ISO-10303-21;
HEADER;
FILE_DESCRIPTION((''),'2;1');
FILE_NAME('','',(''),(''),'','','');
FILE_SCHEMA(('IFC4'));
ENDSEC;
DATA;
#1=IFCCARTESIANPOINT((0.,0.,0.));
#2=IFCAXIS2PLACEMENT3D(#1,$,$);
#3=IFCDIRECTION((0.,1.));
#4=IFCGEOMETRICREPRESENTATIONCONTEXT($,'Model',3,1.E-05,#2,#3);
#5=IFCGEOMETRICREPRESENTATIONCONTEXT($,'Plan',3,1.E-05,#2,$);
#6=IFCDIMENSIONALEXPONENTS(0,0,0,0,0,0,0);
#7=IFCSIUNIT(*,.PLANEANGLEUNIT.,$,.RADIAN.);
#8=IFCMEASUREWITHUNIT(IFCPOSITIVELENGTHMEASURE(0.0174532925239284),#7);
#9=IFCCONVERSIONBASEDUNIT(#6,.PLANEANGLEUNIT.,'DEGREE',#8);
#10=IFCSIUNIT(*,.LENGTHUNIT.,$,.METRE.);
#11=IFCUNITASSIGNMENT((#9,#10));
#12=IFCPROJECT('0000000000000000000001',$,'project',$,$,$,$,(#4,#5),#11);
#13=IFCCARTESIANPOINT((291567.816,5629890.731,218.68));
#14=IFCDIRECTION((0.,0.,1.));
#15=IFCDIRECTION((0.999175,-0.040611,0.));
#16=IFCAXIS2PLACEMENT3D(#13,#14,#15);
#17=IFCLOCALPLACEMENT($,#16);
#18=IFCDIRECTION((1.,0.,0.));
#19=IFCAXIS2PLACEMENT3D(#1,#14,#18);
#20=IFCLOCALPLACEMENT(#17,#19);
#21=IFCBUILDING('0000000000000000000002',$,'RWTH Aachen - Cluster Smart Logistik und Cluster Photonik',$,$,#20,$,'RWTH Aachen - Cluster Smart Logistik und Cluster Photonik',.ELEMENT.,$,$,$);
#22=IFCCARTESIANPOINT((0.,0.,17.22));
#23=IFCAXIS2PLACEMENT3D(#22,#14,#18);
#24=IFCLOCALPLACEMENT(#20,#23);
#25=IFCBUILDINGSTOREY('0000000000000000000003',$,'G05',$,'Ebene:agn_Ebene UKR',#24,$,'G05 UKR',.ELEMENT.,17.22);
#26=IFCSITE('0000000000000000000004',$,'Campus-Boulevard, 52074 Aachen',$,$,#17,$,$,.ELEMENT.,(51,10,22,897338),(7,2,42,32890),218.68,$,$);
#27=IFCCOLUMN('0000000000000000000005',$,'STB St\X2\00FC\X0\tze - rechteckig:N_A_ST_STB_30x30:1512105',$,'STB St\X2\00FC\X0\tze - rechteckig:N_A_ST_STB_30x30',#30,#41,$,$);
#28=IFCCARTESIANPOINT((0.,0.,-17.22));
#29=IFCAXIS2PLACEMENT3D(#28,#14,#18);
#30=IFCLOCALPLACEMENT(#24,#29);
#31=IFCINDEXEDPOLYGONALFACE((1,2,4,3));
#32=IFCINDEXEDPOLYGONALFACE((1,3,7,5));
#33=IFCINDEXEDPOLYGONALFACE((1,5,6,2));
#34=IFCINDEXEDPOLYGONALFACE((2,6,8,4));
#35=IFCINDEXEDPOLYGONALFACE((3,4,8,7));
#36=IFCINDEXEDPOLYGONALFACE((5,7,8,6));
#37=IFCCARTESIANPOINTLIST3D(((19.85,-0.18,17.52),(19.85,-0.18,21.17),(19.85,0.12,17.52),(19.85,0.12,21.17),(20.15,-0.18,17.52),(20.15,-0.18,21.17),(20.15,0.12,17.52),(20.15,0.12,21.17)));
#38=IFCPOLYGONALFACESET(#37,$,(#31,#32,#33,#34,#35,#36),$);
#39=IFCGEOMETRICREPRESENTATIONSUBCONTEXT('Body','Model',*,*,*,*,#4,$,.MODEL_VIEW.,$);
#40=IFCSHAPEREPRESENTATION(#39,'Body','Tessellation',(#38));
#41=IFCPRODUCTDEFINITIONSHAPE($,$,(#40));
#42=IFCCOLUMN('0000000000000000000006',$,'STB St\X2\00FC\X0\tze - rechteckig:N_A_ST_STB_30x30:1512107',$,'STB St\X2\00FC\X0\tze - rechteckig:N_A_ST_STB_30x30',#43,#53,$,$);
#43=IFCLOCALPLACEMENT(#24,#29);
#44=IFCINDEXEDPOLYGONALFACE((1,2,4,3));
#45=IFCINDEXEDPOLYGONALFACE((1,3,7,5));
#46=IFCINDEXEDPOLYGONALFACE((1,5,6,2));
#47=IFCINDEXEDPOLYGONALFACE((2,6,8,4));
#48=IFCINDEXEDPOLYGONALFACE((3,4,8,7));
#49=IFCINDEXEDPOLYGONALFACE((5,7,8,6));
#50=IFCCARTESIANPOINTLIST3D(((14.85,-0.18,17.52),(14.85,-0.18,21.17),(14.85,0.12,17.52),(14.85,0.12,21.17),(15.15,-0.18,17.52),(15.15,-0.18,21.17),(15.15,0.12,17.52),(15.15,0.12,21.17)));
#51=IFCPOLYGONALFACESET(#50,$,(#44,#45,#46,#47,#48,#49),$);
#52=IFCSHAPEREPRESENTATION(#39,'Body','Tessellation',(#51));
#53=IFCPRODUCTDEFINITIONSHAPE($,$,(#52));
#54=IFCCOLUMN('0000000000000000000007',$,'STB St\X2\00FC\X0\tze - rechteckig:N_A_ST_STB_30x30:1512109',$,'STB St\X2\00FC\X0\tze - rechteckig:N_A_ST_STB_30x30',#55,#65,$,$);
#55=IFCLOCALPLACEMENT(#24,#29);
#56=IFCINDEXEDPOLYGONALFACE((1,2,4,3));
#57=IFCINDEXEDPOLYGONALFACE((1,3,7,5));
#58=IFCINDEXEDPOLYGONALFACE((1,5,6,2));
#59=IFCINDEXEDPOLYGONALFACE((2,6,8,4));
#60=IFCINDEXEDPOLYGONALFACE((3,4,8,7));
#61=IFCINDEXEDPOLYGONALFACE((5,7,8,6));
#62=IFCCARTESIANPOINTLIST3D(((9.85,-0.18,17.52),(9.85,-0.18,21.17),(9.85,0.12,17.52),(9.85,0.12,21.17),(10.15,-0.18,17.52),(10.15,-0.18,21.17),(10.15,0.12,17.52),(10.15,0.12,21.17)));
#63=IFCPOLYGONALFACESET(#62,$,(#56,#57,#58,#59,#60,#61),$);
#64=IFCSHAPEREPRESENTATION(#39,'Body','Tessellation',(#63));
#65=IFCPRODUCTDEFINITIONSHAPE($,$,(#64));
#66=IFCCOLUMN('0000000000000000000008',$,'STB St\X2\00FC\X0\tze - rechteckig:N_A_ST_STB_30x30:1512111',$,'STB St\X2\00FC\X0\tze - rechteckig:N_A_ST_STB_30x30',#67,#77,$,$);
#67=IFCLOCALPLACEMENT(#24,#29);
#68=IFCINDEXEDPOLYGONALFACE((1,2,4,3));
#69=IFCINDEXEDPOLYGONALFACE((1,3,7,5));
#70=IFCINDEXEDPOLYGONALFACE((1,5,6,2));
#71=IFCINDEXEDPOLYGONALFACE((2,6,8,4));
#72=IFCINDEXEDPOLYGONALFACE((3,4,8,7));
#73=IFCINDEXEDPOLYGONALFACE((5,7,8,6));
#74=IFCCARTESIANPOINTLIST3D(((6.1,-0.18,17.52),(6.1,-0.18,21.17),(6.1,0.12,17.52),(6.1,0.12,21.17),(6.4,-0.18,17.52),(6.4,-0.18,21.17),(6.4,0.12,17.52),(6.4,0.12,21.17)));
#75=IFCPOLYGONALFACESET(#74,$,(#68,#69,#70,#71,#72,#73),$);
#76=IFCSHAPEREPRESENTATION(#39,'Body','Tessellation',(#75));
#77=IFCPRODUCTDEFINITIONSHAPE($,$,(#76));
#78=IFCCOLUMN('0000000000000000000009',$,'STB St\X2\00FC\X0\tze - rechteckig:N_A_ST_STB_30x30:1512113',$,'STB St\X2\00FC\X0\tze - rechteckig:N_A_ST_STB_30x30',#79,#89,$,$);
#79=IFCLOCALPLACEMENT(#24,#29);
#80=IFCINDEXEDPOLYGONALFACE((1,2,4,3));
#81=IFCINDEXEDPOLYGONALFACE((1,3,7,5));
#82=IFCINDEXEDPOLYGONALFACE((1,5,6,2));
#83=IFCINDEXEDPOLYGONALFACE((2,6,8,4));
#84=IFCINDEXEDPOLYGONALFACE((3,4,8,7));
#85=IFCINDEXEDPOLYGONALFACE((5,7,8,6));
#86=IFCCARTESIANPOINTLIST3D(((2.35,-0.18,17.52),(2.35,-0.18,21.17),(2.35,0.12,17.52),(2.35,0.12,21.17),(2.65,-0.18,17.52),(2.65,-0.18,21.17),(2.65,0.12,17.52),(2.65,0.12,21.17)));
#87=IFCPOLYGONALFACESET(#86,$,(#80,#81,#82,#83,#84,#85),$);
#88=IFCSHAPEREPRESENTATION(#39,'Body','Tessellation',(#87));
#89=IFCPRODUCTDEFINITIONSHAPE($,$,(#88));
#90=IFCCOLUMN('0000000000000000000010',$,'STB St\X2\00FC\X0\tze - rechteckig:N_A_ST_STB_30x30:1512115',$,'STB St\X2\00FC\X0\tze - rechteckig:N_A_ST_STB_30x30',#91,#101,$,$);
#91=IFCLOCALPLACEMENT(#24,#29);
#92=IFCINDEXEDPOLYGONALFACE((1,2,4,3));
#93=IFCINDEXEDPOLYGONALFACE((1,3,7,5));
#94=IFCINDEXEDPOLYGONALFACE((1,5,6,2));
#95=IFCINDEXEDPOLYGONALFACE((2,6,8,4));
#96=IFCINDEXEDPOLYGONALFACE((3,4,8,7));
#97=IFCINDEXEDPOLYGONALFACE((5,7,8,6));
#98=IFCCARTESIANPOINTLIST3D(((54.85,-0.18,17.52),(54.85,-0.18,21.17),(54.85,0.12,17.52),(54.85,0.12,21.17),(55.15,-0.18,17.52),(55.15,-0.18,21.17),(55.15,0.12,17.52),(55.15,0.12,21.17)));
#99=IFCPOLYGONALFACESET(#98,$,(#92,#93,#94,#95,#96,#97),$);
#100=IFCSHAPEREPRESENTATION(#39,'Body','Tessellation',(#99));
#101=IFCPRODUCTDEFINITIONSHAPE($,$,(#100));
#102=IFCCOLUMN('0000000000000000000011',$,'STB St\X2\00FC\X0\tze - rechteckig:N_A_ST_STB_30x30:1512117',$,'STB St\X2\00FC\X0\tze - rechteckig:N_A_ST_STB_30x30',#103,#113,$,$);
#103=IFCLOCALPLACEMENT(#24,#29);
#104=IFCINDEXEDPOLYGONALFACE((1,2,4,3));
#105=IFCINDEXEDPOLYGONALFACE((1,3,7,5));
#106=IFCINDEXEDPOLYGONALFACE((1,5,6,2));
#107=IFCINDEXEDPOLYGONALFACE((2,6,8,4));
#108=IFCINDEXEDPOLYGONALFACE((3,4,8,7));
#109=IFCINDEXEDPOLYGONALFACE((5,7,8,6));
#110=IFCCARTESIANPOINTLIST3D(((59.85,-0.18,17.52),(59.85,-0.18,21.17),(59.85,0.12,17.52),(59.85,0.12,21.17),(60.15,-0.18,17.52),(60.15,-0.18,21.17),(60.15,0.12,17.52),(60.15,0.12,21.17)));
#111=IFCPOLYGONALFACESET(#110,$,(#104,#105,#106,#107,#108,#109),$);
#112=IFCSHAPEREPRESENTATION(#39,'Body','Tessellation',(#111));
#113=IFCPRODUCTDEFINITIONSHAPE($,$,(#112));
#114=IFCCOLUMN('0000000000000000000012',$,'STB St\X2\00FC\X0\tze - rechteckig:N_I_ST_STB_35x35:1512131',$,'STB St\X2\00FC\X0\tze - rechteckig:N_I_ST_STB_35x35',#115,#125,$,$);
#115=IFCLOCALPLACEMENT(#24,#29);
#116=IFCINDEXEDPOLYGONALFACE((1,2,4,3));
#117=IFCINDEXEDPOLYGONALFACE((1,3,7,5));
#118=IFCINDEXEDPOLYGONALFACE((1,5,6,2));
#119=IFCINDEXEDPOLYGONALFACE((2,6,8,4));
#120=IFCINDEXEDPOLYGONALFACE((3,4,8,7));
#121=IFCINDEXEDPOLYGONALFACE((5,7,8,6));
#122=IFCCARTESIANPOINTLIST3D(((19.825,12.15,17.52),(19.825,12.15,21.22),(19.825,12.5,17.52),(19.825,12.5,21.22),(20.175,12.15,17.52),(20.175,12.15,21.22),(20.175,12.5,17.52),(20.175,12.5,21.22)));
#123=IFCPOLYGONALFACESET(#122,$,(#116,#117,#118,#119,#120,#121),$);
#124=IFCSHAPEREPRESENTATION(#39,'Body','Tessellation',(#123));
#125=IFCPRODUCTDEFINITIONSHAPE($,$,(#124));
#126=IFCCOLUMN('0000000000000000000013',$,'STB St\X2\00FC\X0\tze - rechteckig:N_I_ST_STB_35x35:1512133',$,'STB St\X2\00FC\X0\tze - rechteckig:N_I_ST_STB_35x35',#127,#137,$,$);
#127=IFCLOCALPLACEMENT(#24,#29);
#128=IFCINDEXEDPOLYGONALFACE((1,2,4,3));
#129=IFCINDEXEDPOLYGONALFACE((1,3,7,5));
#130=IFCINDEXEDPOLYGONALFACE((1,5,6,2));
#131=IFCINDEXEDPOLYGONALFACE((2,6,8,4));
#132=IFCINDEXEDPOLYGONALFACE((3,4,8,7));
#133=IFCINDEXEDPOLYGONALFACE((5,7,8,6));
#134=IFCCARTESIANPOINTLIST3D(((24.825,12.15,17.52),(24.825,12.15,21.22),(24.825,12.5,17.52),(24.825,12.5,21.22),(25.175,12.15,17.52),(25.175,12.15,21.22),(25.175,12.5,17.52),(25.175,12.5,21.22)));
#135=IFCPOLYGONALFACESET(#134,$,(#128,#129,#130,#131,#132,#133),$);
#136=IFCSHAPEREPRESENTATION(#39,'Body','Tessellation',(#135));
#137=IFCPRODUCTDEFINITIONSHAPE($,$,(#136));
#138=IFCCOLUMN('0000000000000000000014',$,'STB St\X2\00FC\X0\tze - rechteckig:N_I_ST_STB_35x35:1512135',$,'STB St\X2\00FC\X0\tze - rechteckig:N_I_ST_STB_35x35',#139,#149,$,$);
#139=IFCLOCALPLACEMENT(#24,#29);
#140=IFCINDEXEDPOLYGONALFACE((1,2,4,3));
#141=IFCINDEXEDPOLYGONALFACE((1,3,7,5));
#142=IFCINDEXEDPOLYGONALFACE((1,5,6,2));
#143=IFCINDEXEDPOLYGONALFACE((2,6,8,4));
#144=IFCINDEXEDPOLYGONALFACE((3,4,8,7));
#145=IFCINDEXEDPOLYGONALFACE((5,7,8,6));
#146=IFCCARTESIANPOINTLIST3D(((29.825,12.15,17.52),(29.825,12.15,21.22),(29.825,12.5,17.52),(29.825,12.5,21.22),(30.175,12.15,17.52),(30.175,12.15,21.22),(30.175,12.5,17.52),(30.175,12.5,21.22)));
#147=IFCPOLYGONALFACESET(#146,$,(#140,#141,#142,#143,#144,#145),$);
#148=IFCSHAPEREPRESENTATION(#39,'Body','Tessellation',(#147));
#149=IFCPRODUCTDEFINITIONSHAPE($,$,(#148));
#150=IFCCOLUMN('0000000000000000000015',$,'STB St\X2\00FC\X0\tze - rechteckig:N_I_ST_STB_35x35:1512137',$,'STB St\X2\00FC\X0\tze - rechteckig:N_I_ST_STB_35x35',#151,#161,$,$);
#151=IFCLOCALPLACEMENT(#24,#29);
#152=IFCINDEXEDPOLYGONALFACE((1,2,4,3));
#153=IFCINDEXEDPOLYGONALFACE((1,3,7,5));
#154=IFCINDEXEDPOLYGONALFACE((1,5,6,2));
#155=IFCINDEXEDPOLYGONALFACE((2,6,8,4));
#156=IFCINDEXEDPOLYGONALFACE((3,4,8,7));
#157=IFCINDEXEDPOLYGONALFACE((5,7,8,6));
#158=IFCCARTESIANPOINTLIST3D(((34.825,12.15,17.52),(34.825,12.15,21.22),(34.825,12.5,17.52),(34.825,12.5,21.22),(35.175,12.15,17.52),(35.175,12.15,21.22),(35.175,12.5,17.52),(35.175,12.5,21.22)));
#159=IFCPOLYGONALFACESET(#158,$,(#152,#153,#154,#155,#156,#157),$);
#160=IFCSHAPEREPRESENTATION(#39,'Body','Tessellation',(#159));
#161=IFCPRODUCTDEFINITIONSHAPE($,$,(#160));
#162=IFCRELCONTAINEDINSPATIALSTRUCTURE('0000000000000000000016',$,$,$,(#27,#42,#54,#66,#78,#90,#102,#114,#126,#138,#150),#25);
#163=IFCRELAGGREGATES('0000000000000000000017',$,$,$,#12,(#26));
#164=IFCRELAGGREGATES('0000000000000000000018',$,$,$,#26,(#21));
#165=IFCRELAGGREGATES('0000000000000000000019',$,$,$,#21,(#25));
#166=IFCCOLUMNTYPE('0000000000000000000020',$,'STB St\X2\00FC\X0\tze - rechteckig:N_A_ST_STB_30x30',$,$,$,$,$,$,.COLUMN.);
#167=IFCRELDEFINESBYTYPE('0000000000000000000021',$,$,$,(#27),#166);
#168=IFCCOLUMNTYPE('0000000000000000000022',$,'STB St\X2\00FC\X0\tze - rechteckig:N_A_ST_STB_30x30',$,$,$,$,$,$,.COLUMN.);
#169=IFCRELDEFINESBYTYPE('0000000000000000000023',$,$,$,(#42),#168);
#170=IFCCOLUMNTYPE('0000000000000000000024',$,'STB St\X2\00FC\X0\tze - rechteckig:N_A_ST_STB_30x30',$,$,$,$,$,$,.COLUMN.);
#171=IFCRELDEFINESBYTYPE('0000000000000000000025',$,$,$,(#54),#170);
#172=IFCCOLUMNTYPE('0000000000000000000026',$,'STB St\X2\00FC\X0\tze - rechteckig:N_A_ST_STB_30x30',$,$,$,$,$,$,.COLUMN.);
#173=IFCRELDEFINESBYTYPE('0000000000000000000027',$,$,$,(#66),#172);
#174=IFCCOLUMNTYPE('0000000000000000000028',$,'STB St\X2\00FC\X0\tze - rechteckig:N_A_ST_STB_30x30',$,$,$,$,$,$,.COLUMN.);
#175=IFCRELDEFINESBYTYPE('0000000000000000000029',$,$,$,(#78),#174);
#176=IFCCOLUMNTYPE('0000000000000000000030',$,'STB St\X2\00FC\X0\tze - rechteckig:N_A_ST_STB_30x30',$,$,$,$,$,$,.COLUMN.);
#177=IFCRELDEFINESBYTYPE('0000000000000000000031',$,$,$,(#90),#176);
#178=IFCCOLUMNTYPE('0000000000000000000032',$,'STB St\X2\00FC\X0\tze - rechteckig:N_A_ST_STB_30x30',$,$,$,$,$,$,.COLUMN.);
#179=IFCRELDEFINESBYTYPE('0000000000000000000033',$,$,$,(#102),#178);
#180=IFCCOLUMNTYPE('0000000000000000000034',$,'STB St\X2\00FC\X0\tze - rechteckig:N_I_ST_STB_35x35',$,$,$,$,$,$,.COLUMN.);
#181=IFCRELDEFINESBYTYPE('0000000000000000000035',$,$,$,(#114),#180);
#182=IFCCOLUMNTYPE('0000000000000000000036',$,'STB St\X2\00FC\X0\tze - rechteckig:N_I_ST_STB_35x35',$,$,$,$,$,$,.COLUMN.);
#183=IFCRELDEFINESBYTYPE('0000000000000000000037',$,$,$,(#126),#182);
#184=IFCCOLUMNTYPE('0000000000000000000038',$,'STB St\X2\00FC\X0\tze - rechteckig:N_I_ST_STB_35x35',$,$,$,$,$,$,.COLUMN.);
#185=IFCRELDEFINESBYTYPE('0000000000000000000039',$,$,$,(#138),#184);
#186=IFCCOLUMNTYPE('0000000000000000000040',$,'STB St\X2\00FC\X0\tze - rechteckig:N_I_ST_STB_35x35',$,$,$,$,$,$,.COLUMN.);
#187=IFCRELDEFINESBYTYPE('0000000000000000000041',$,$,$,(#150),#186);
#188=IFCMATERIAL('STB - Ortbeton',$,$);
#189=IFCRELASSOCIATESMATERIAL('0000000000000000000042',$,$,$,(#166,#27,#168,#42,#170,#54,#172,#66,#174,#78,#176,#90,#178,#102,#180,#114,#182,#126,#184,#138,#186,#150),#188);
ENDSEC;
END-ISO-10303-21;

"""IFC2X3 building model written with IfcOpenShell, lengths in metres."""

from ifc_helpers import new_model, entity, si_unit, converted_unit, direction, frame, frame_2d, origin, origin_with_axes, origin_2d_with_axis, place, context, subcontext, project, spatial, rectangle, extrude, source, transform, mapped, material, type_object, element, save


model = new_model("IFC2X3")

# Units and contexts
model_context = context("Model", 3, precision=1e-05, world=origin(), true_north=direction((0.0, 1.0)))
plan_context = context("Plan", 3, precision=1e-05, world=origin())
body_context = subcontext(model_context, "Body", "Model", "MODEL_VIEW")
ifc_project = project(units=[converted_unit("PLANEANGLEUNIT", "DEGREE", entity("IfcPositiveLengthMeasure", 0.0174532925239284), si_unit("PLANEANGLEUNIT", "RADIAN"), dimensions=[0, 0, 0, 0, 0, 0, 0]), si_unit("LENGTHUNIT", "METRE")], contexts=[model_context, plan_context])

# Site, building, storey
site_placement = place(None, frame((291567.816, 5629890.731, 218.68), z_axis=(0.0, 0.0, 1.0), x_axis=(0.999175, -0.040611, 0.0)))
site = spatial("IfcSite", under=ifc_project, at=site_placement, Name="Campus-Boulevard, 52074 Aachen", CompositionType="ELEMENT", RefLatitude=(51, 10, 22, 897338), RefLongitude=(7, 2, 42, 32890), RefElevation=218.68)
building_placement = place(site_placement, origin_with_axes())
building = spatial("IfcBuilding", under=site, at=building_placement, Name="RWTH Aachen - Cluster Smart Logistik und Cluster Photonik", LongName="RWTH Aachen - Cluster Smart Logistik und Cluster Photonik", CompositionType="ELEMENT")
storey_placement = place(building_placement, frame((0.0, 0.0, 17.22), z_axis=(0.0, 0.0, 1.0), x_axis=(1.0, 0.0, 0.0)))
storey = spatial("IfcBuildingStorey", under=building, at=storey_placement, Name="G05", ObjectType="Ebene:agn_Ebene UKR", LongName="G05 UKR", CompositionType="ELEMENT", Elevation=17.22)

# Columns
ifc_material_1 = material(Name="STB - Ortbeton")
column_type_1 = type_object("IfcColumnType", Name="STB Stütze - rechteckig:N_A_ST_STB_30x30", PredefinedType="COLUMN", material=ifc_material_1)
shared_shape_1 = source(origin(), body_context, "Body", "SweptSolid", [
    extrude(rectangle(XDim=0.3, YDim=0.3, at=origin_2d_with_axis()), frame((20.0, -0.03, 17.52), z_axis=(0.0, 0.0, 1.0), x_axis=(0.0, -1.0, 0.0)), (0.0, 0.0, 1.0), 3.65),
])
column_1_placement = place(storey_placement, frame((0.0, 0.0, -17.22), z_axis=(0.0, 0.0, 1.0), x_axis=(1.0, 0.0, 0.0)))
element("IfcColumn", 1, at=column_1_placement, inside=storey, type_object=column_type_1, material=ifc_material_1, Name="STB Stütze - rechteckig:N_A_ST_STB_30x30:1512105", ObjectType="STB Stütze - rechteckig:N_A_ST_STB_30x30", context=body_context, shape_type="MappedRepresentation", body=[
    mapped(shared_shape_1, transform((0.0, 0.0, 0.0), scale=1.0)),
])
column_type_2 = type_object("IfcColumnType", Name="STB Stütze - rechteckig:N_A_ST_STB_30x30", PredefinedType="COLUMN", material=ifc_material_1)
shared_shape_2 = source(origin(), body_context, "Body", "SweptSolid", [
    extrude(rectangle(XDim=0.3, YDim=0.3, at=origin_2d_with_axis()), frame((15.0, -0.03, 17.52), z_axis=(0.0, 0.0, 1.0), x_axis=(0.0, -1.0, 0.0)), (0.0, 0.0, 1.0), 3.65),
])
column_2_placement = place(storey_placement, frame((0.0, 0.0, -17.22), z_axis=(0.0, 0.0, 1.0), x_axis=(1.0, 0.0, 0.0)))
element("IfcColumn", 2, at=column_2_placement, inside=storey, type_object=column_type_2, material=ifc_material_1, Name="STB Stütze - rechteckig:N_A_ST_STB_30x30:1512107", ObjectType="STB Stütze - rechteckig:N_A_ST_STB_30x30", context=body_context, shape_type="MappedRepresentation", body=[
    mapped(shared_shape_2, transform((0.0, 0.0, 0.0), scale=1.0)),
])
column_type_3 = type_object("IfcColumnType", Name="STB Stütze - rechteckig:N_A_ST_STB_30x30", PredefinedType="COLUMN", material=ifc_material_1)
shared_shape_3 = source(origin(), body_context, "Body", "SweptSolid", [
    extrude(rectangle(XDim=0.3, YDim=0.3, at=origin_2d_with_axis()), frame((10.0, -0.03, 17.52), z_axis=(0.0, 0.0, 1.0), x_axis=(0.0, -1.0, 0.0)), (0.0, 0.0, 1.0), 3.65),
])
column_3_placement = place(storey_placement, frame((0.0, 0.0, -17.22), z_axis=(0.0, 0.0, 1.0), x_axis=(1.0, 0.0, 0.0)))
element("IfcColumn", 3, at=column_3_placement, inside=storey, type_object=column_type_3, material=ifc_material_1, Name="STB Stütze - rechteckig:N_A_ST_STB_30x30:1512109", ObjectType="STB Stütze - rechteckig:N_A_ST_STB_30x30", context=body_context, shape_type="MappedRepresentation", body=[
    mapped(shared_shape_3, transform((0.0, 0.0, 0.0), scale=1.0)),
])
column_type_4 = type_object("IfcColumnType", Name="STB Stütze - rechteckig:N_A_ST_STB_30x30", PredefinedType="COLUMN", material=ifc_material_1)
shared_shape_4 = source(origin(), body_context, "Body", "SweptSolid", [
    extrude(rectangle(XDim=0.3, YDim=0.3, at=frame_2d((0.0, 0.0), x_axis=(1.0, 0.0))), frame((6.25, -0.03, 17.52), z_axis=(0.0, 0.0, 1.0), x_axis=(0.0, -1.0, 0.0)), (0.0, 0.0, 1.0), 3.65),
])
column_4_placement = place(storey_placement, frame((0.0, 0.0, -17.22), z_axis=(0.0, 0.0, 1.0), x_axis=(1.0, 0.0, 0.0)))
element("IfcColumn", 4, at=column_4_placement, inside=storey, type_object=column_type_4, material=ifc_material_1, Name="STB Stütze - rechteckig:N_A_ST_STB_30x30:1512111", ObjectType="STB Stütze - rechteckig:N_A_ST_STB_30x30", context=body_context, shape_type="MappedRepresentation", body=[
    mapped(shared_shape_4, transform((0.0, 0.0, 0.0), scale=1.0)),
])
column_type_5 = type_object("IfcColumnType", Name="STB Stütze - rechteckig:N_A_ST_STB_30x30", PredefinedType="COLUMN", material=ifc_material_1)
shared_shape_5 = source(origin(), body_context, "Body", "SweptSolid", [
    extrude(rectangle(XDim=0.3, YDim=0.3, at=origin_2d_with_axis()), frame((2.5, -0.03, 17.52), z_axis=(0.0, 0.0, 1.0), x_axis=(0.0, -1.0, 0.0)), (0.0, 0.0, 1.0), 3.65),
])
column_5_placement = place(storey_placement, frame((0.0, 0.0, -17.22), z_axis=(0.0, 0.0, 1.0), x_axis=(1.0, 0.0, 0.0)))
element("IfcColumn", 5, at=column_5_placement, inside=storey, type_object=column_type_5, material=ifc_material_1, Name="STB Stütze - rechteckig:N_A_ST_STB_30x30:1512113", ObjectType="STB Stütze - rechteckig:N_A_ST_STB_30x30", context=body_context, shape_type="MappedRepresentation", body=[
    mapped(shared_shape_5, transform((0.0, 0.0, 0.0), scale=1.0)),
])
column_type_6 = type_object("IfcColumnType", Name="STB Stütze - rechteckig:N_A_ST_STB_30x30", PredefinedType="COLUMN", material=ifc_material_1)
shared_shape_6 = source(origin(), body_context, "Body", "SweptSolid", [
    extrude(rectangle(XDim=0.3, YDim=0.3, at=origin_2d_with_axis()), frame((55.0, -0.03, 17.52), z_axis=(0.0, 0.0, 1.0), x_axis=(0.0, -1.0, 0.0)), (0.0, 0.0, 1.0), 3.65),
])
column_6_placement = place(storey_placement, frame((0.0, 0.0, -17.22), z_axis=(0.0, 0.0, 1.0), x_axis=(1.0, 0.0, 0.0)))
element("IfcColumn", 6, at=column_6_placement, inside=storey, type_object=column_type_6, material=ifc_material_1, Name="STB Stütze - rechteckig:N_A_ST_STB_30x30:1512115", ObjectType="STB Stütze - rechteckig:N_A_ST_STB_30x30", context=body_context, shape_type="MappedRepresentation", body=[
    mapped(shared_shape_6, transform((0.0, 0.0, 0.0), scale=1.0)),
])
column_type_7 = type_object("IfcColumnType", Name="STB Stütze - rechteckig:N_A_ST_STB_30x30", PredefinedType="COLUMN", material=ifc_material_1)
shared_shape_7 = source(origin(), body_context, "Body", "SweptSolid", [
    extrude(rectangle(XDim=0.3, YDim=0.3, at=origin_2d_with_axis()), frame((60.0, -0.03, 17.52), z_axis=(0.0, 0.0, 1.0), x_axis=(0.0, -1.0, 0.0)), (0.0, 0.0, 1.0), 3.65),
])
column_7_placement = place(storey_placement, frame((0.0, 0.0, -17.22), z_axis=(0.0, 0.0, 1.0), x_axis=(1.0, 0.0, 0.0)))
element("IfcColumn", 7, at=column_7_placement, inside=storey, type_object=column_type_7, material=ifc_material_1, Name="STB Stütze - rechteckig:N_A_ST_STB_30x30:1512117", ObjectType="STB Stütze - rechteckig:N_A_ST_STB_30x30", context=body_context, shape_type="MappedRepresentation", body=[
    mapped(shared_shape_7, transform((0.0, 0.0, 0.0), scale=1.0)),
])
column_type_8 = type_object("IfcColumnType", Name="STB Stütze - rechteckig:N_I_ST_STB_35x35", PredefinedType="COLUMN", material=ifc_material_1)
shared_shape_8 = source(origin(), body_context, "Body", "SweptSolid", [
    extrude(rectangle(XDim=0.35, YDim=0.35, at=origin_2d_with_axis()), frame((20.0, 12.325, 17.52), z_axis=(0.0, 0.0, 1.0), x_axis=(0.0, -1.0, 0.0)), (0.0, 0.0, 1.0), 3.7),
])
column_8_placement = place(storey_placement, frame((0.0, 0.0, -17.22), z_axis=(0.0, 0.0, 1.0), x_axis=(1.0, 0.0, 0.0)))
element("IfcColumn", 8, at=column_8_placement, inside=storey, type_object=column_type_8, material=ifc_material_1, Name="STB Stütze - rechteckig:N_I_ST_STB_35x35:1512131", ObjectType="STB Stütze - rechteckig:N_I_ST_STB_35x35", context=body_context, shape_type="MappedRepresentation", body=[
    mapped(shared_shape_8, transform((0.0, 0.0, 0.0), scale=1.0)),
])
column_type_9 = type_object("IfcColumnType", Name="STB Stütze - rechteckig:N_I_ST_STB_35x35", PredefinedType="COLUMN", material=ifc_material_1)
shared_shape_9 = source(origin(), body_context, "Body", "SweptSolid", [
    extrude(rectangle(XDim=0.35, YDim=0.35, at=origin_2d_with_axis()), frame((25.0, 12.325, 17.52), z_axis=(0.0, 0.0, 1.0), x_axis=(0.0, -1.0, 0.0)), (0.0, 0.0, 1.0), 3.7),
])
column_9_placement = place(storey_placement, frame((0.0, 0.0, -17.22), z_axis=(0.0, 0.0, 1.0), x_axis=(1.0, 0.0, 0.0)))
element("IfcColumn", 9, at=column_9_placement, inside=storey, type_object=column_type_9, material=ifc_material_1, Name="STB Stütze - rechteckig:N_I_ST_STB_35x35:1512133", ObjectType="STB Stütze - rechteckig:N_I_ST_STB_35x35", context=body_context, shape_type="MappedRepresentation", body=[
    mapped(shared_shape_9, transform((0.0, 0.0, 0.0), scale=1.0)),
])
column_type_10 = type_object("IfcColumnType", Name="STB Stütze - rechteckig:N_I_ST_STB_35x35", PredefinedType="COLUMN", material=ifc_material_1)
shared_shape_10 = source(origin(), body_context, "Body", "SweptSolid", [
    extrude(rectangle(XDim=0.35, YDim=0.35, at=origin_2d_with_axis()), frame((30.0, 12.325, 17.52), z_axis=(0.0, 0.0, 1.0), x_axis=(0.0, -1.0, 0.0)), (0.0, 0.0, 1.0), 3.7),
])
column_10_placement = place(storey_placement, frame((0.0, 0.0, -17.22), z_axis=(0.0, 0.0, 1.0), x_axis=(1.0, 0.0, 0.0)))
element("IfcColumn", 10, at=column_10_placement, inside=storey, type_object=column_type_10, material=ifc_material_1, Name="STB Stütze - rechteckig:N_I_ST_STB_35x35:1512135", ObjectType="STB Stütze - rechteckig:N_I_ST_STB_35x35", context=body_context, shape_type="MappedRepresentation", body=[
    mapped(shared_shape_10, transform((0.0, 0.0, 0.0), scale=1.0)),
])
column_type_11 = type_object("IfcColumnType", Name="STB Stütze - rechteckig:N_I_ST_STB_35x35", PredefinedType="COLUMN", material=ifc_material_1)
shared_shape_11 = source(origin(), body_context, "Body", "SweptSolid", [
    extrude(rectangle(XDim=0.35, YDim=0.35, at=origin_2d_with_axis()), frame((35.0, 12.325, 17.52), z_axis=(0.0, 0.0, 1.0), x_axis=(0.0, -1.0, 0.0)), (0.0, 0.0, 1.0), 3.7),
])
column_11_placement = place(storey_placement, frame((0.0, 0.0, -17.22), z_axis=(0.0, 0.0, 1.0), x_axis=(1.0, 0.0, 0.0)))
element("IfcColumn", 11, at=column_11_placement, inside=storey, type_object=column_type_11, material=ifc_material_1, Name="STB Stütze - rechteckig:N_I_ST_STB_35x35:1512137", ObjectType="STB Stütze - rechteckig:N_I_ST_STB_35x35", context=body_context, shape_type="MappedRepresentation", body=[
    mapped(shared_shape_11, transform((0.0, 0.0, 0.0), scale=1.0)),
])

save(model, "model.ifc")
